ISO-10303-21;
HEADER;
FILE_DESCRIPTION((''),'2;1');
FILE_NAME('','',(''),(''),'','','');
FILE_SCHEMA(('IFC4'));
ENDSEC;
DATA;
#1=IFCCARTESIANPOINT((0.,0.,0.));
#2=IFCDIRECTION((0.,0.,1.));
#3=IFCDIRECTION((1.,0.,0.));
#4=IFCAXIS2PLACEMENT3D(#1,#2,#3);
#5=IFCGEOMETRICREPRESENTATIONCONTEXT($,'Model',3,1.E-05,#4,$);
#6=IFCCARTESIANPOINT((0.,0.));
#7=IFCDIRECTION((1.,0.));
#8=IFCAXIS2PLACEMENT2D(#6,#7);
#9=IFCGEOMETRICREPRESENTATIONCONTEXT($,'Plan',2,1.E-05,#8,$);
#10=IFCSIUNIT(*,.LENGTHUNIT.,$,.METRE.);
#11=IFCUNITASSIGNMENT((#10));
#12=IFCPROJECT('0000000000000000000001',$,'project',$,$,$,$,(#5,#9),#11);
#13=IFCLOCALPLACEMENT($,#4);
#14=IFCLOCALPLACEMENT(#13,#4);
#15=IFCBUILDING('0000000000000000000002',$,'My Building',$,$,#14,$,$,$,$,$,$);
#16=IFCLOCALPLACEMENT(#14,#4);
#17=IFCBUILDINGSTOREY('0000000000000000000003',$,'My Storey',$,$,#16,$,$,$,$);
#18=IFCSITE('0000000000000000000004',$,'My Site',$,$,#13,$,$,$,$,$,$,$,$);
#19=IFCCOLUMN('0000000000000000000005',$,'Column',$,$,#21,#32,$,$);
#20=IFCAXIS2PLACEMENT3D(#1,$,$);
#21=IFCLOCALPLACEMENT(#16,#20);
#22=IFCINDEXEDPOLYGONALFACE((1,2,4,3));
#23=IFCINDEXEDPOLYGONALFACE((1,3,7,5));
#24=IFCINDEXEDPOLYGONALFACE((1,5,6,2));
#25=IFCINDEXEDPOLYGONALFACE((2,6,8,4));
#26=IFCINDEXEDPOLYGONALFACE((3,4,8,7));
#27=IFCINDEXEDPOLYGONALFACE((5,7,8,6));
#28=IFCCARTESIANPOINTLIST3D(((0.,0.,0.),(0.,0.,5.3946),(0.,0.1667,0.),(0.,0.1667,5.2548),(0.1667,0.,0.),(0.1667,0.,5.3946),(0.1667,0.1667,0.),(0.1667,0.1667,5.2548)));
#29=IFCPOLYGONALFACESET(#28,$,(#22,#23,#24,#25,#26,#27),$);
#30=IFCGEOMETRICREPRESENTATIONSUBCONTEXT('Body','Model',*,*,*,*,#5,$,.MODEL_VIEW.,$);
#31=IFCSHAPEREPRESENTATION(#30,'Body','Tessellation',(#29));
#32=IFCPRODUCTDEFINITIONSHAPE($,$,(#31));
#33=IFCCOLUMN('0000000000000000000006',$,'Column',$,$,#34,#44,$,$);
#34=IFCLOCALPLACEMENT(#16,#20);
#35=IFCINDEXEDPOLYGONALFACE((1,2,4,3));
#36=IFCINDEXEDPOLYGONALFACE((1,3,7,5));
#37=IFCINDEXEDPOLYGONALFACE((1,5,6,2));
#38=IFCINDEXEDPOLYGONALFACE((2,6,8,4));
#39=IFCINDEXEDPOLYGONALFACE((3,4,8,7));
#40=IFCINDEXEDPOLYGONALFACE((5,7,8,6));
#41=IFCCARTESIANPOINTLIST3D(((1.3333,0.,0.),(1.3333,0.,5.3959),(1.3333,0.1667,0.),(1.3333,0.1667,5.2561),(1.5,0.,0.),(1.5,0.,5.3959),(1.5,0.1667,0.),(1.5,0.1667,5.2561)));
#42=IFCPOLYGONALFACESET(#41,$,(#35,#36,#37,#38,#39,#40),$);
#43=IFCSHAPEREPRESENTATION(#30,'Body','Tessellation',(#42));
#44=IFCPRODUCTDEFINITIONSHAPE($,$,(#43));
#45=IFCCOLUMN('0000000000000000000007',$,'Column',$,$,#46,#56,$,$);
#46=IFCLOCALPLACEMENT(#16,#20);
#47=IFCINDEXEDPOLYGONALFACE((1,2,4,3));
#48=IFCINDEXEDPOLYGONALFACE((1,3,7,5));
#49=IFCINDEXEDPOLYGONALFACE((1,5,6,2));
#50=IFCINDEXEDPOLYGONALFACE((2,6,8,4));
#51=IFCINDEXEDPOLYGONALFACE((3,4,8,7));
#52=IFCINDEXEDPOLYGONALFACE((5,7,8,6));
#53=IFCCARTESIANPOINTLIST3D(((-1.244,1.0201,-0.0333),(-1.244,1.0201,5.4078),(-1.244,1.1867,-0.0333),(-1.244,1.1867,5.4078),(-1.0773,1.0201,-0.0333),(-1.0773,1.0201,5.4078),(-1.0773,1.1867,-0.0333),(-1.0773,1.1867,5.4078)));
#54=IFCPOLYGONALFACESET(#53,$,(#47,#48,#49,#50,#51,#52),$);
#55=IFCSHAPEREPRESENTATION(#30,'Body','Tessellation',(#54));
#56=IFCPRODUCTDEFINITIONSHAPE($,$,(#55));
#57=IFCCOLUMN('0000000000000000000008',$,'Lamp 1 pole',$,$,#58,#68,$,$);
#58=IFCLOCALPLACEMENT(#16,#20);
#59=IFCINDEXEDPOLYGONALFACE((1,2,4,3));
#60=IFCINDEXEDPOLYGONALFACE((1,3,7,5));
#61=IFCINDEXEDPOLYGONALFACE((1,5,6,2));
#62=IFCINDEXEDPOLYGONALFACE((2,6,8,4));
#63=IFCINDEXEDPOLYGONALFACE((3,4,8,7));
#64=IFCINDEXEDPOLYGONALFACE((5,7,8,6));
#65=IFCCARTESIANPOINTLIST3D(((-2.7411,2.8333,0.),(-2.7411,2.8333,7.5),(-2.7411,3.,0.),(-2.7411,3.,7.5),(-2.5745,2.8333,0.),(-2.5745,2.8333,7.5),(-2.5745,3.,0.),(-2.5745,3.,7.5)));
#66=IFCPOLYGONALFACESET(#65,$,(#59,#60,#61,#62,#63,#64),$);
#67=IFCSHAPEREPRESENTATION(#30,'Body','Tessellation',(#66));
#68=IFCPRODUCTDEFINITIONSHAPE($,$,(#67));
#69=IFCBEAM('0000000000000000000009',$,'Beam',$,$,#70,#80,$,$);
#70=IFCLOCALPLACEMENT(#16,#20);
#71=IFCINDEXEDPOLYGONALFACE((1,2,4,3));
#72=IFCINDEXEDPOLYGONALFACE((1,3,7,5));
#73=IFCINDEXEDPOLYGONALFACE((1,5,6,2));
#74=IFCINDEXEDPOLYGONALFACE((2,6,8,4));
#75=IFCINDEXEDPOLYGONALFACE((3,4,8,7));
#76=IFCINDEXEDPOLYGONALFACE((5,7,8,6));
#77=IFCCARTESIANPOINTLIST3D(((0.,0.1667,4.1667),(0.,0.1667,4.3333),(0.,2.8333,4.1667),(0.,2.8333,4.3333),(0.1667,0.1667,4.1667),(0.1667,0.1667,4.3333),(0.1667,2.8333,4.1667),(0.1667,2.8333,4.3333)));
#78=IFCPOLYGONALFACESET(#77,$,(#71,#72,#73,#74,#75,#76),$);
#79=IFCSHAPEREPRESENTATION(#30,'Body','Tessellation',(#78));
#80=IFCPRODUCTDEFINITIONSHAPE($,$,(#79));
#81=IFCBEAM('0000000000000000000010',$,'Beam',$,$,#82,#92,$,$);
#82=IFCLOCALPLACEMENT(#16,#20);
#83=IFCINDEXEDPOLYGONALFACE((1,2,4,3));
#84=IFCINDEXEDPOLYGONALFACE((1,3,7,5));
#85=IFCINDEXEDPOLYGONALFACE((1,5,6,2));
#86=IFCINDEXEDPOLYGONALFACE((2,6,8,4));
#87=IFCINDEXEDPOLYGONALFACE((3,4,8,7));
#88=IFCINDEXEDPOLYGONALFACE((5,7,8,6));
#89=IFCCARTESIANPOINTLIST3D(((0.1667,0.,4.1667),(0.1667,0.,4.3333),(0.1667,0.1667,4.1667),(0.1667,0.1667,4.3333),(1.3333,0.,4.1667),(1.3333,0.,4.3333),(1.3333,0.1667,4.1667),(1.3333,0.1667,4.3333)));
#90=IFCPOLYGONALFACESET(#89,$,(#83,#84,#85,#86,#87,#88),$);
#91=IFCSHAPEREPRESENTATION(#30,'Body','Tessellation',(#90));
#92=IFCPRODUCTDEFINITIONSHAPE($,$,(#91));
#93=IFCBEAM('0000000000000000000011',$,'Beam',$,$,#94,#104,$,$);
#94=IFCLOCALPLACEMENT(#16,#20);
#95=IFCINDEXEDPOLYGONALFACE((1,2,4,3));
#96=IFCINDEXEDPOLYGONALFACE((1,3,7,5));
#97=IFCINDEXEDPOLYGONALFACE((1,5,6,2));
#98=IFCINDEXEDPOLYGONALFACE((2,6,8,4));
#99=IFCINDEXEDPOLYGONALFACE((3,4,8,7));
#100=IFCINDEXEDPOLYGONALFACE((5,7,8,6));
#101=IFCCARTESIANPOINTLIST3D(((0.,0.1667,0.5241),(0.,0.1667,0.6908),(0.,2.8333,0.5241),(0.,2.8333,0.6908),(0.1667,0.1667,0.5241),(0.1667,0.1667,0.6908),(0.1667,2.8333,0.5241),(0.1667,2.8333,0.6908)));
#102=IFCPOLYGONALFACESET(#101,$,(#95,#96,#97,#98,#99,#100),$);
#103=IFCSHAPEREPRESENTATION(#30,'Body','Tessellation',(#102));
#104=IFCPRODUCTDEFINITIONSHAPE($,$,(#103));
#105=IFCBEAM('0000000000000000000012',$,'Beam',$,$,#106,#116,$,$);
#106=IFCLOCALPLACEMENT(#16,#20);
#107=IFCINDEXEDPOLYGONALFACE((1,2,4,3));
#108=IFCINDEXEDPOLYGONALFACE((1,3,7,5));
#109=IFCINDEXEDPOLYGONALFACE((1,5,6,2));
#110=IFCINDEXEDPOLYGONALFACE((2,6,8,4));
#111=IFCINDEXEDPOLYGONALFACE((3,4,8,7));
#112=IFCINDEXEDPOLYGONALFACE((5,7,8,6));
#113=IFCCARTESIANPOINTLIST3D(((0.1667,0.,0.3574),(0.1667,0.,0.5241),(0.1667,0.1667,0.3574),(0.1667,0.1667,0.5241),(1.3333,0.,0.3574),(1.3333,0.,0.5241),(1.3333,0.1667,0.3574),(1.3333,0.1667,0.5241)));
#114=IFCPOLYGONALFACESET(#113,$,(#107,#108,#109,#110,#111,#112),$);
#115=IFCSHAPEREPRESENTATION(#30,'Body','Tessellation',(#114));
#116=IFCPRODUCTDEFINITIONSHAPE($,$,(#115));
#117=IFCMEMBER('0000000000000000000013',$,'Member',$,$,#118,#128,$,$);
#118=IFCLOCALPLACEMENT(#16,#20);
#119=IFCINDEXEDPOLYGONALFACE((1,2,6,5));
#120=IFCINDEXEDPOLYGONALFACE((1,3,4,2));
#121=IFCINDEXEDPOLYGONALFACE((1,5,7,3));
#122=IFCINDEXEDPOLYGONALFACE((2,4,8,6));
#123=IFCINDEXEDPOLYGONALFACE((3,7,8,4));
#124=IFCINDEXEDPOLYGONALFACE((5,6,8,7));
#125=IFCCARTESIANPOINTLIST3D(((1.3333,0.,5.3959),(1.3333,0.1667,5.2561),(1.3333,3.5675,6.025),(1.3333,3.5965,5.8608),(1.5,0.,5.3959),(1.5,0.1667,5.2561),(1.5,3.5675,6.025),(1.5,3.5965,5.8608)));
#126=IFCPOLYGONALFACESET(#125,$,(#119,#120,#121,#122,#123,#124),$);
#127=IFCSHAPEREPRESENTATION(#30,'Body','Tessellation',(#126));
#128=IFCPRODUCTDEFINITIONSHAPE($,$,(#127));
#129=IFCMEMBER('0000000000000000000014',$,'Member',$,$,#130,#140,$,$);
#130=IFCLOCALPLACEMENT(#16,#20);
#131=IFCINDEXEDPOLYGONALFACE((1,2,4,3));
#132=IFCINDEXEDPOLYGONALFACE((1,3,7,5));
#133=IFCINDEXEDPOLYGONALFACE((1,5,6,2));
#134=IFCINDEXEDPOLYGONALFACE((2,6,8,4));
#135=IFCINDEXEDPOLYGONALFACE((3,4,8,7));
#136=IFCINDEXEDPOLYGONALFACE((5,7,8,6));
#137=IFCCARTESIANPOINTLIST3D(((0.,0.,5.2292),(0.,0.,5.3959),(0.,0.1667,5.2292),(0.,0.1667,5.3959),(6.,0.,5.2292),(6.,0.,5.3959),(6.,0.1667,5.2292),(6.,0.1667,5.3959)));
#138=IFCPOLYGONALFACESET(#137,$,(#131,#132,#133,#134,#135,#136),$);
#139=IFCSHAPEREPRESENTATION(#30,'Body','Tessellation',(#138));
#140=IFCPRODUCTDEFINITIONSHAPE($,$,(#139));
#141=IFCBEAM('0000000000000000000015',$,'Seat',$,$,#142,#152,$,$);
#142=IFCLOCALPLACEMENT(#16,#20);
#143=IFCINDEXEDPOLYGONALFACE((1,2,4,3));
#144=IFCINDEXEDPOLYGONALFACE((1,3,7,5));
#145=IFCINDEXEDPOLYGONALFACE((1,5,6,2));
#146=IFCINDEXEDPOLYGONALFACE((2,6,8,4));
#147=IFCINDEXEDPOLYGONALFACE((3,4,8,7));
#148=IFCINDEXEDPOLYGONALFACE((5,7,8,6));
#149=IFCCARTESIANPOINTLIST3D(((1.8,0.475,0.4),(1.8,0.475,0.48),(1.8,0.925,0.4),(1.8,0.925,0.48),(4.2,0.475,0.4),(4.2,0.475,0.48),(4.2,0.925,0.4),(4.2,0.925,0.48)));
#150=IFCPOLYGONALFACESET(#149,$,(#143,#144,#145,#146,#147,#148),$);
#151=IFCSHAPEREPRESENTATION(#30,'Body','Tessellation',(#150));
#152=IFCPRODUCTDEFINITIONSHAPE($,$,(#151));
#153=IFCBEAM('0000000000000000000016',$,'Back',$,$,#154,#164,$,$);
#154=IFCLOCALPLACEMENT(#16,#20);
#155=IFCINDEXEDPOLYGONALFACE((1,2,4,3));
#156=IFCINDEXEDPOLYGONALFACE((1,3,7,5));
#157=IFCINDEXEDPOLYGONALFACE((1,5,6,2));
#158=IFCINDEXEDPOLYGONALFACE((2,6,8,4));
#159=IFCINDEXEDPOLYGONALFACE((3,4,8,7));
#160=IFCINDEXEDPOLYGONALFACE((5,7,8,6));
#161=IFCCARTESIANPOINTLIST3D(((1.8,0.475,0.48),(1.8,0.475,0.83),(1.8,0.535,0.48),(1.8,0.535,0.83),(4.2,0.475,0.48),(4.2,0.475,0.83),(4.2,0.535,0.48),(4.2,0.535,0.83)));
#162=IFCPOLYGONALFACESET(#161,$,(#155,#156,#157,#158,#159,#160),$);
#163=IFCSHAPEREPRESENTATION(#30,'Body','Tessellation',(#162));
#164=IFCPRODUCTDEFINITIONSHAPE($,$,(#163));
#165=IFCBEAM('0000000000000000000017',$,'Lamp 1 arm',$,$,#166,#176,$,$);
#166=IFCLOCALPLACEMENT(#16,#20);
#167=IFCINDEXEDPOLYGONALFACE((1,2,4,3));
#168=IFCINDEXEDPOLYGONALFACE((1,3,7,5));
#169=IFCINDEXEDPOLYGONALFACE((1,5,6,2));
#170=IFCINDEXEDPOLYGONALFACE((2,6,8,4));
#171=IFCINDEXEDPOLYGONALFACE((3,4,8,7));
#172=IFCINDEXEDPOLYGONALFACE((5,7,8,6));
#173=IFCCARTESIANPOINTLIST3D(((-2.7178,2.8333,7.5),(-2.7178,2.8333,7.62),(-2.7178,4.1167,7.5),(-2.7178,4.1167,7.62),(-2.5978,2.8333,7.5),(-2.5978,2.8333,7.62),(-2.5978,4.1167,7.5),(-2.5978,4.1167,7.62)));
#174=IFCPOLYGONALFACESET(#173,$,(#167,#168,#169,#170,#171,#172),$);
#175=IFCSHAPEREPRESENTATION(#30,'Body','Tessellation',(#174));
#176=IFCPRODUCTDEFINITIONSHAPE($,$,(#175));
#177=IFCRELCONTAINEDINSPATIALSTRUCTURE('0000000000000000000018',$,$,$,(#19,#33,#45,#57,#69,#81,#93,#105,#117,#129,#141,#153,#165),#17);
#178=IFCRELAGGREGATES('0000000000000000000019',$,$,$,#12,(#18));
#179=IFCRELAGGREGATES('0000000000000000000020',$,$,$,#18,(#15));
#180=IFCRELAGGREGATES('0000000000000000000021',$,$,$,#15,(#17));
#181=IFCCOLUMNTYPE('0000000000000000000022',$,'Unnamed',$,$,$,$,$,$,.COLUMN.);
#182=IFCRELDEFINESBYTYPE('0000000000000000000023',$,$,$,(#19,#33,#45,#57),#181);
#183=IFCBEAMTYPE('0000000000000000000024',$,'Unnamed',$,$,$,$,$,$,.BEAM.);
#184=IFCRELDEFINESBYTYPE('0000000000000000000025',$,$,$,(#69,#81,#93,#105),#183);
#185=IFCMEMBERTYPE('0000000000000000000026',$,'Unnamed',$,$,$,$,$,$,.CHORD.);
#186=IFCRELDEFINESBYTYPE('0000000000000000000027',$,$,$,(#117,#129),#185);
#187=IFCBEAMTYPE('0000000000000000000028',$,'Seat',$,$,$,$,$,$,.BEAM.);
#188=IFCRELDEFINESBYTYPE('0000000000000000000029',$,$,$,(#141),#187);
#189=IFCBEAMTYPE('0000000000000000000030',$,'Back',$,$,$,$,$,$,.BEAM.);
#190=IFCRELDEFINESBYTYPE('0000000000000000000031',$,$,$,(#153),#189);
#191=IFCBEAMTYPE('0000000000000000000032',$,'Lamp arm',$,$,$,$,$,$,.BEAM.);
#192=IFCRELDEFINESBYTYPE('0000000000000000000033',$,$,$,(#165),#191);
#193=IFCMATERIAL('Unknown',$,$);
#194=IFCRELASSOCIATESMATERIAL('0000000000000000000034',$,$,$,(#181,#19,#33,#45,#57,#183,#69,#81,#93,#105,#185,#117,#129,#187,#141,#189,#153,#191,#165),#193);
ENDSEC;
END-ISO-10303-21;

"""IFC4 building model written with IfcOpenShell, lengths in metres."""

from ifc_helpers import new_model, si_unit, frame, origin_with_axes, origin_2d_with_axis, place, context, subcontext, project, spatial, rectangle, extrude, clip, halfspace, material, material_profile, profile_set, profile_usage, type_object, element, save


model = new_model("IFC4")

# Units and contexts
model_context = context("Model", 3, precision=1e-05, world=origin_with_axes())
plan_context = context("Plan", 2, precision=1e-05, world=origin_2d_with_axis())
body_context = subcontext(model_context, "Body", "Model", "MODEL_VIEW")
ifc_project = project(units=[si_unit("LENGTHUNIT", "METRE")], contexts=[model_context, plan_context])

# Site, building, storey
site_placement = place(None, origin_with_axes())
site = spatial("IfcSite", under=ifc_project, at=site_placement, Name="My Site")
building_placement = place(site_placement, origin_with_axes())
building = spatial("IfcBuilding", under=site, at=building_placement, Name="My Building")
storey_placement = place(building_placement, origin_with_axes())
storey = spatial("IfcBuildingStorey", under=building, at=storey_placement, Name="My Storey")

# Columns
ifc_material = material(Name="Unknown")
ifc_material_profile_1 = material_profile(ifc_material, rectangle(XDim=0.1667, YDim=0.1667))
ifc_profile_set_1 = profile_set([ifc_material_profile_1])
column_type = type_object("IfcColumnType", Name="Unnamed", PredefinedType="COLUMN", material=ifc_profile_set_1)
ifc_profile_usage_1 = profile_usage(ifc_profile_set_1, cardinal=5)
column_1_placement = place(storey_placement, frame((0.0833, 0.0833, 0.0), z_axis=(0.0, 0.0, 1.0), x_axis=(1.0, 0.0, 0.0)))
element("IfcColumn", 1, at=column_1_placement, inside=storey, type_object=column_type, material=ifc_profile_usage_1, Name="Column", context=body_context, shape_type="Clipping", body=[
    clip(extrude(rectangle(XDim=0.1667, YDim=0.1667), origin_with_axes(), (0.0, 0.0, 1.0), 5.576), halfspace(frame((-0.0833, -0.0833, 5.3946), z_axis=(0.0, 0.642787, 0.766045), x_axis=(1.0, 0.0, 0.0)), False)),
])
ifc_profile_usage_2 = profile_usage(ifc_profile_set_1, cardinal=5)
column_2_placement = place(storey_placement, frame((1.4167, 0.0833, 0.0), z_axis=(0.0, 0.0, 1.0), x_axis=(1.0, 0.0, 0.0)))
element("IfcColumn", 2, at=column_2_placement, inside=storey, type_object=column_type, material=ifc_profile_usage_2, Name="Column", context=body_context, shape_type="Clipping", body=[
    clip(extrude(rectangle(XDim=0.1667, YDim=0.1667), origin_with_axes(), (0.0, 0.0, 1.0), 5.5773), halfspace(frame((-1.4167, -0.0833, 5.3959), z_axis=(0.0, 0.642787, 0.766045), x_axis=(1.0, 0.0, 0.0)), False)),
])
ifc_profile_usage_3 = profile_usage(ifc_profile_set_1, cardinal=5)
column_3_placement = place(storey_placement, frame((-1.1606, 1.1034, -0.0333), z_axis=(0.0, 0.0, 1.0), x_axis=(1.0, 0.0, 0.0)))
element("IfcColumn", 3, at=column_3_placement, inside=storey, type_object=column_type, material=ifc_profile_usage_3, Name="Column", context=body_context, shape_type="SweptSolid", body=[
    extrude(rectangle(XDim=0.1667, YDim=0.1667), origin_with_axes(), (0.0, 0.0, 1.0), 5.4411),
])
ifc_profile_usage_4 = profile_usage(ifc_profile_set_1, cardinal=5)
column_4_placement = place(storey_placement, frame((-2.6578, 2.9167, 0.0), z_axis=(0.0, 0.0, 1.0), x_axis=(1.0, 0.0, 0.0)))
element("IfcColumn", 4, at=column_4_placement, inside=storey, type_object=column_type, material=ifc_profile_usage_4, Name="Lamp 1 pole", context=body_context, shape_type="SweptSolid", body=[
    extrude(rectangle(XDim=0.1667, YDim=0.1667), origin_with_axes(), (0.0, 0.0, 1.0), 7.5),
])

# Beams
ifc_material_profile_2 = material_profile(ifc_material, rectangle(XDim=0.1667, YDim=0.1667))
ifc_profile_set_2 = profile_set([ifc_material_profile_2])
ifc_profile_usage_5 = profile_usage(ifc_profile_set_2, cardinal=5)
beam_type_1 = type_object("IfcBeamType", Name="Unnamed", PredefinedType="BEAM", material=ifc_profile_set_2)
beam_1_placement = place(storey_placement, frame((0.0833, 2.8333, 4.25), z_axis=(0.000003, -1.0, 0.0), x_axis=(1.0, 0.000003, 0.0)))
element("IfcBeam", 5, at=beam_1_placement, inside=storey, type_object=beam_type_1, material=ifc_profile_usage_5, Name="Beam", context=body_context, shape_type="SweptSolid", body=[
    extrude(rectangle(XDim=0.1667, YDim=0.1667), origin_with_axes(), (0.0, 0.0, 1.0), 2.6667),
])
ifc_profile_usage_6 = profile_usage(ifc_profile_set_2, cardinal=5)
beam_2_placement = place(storey_placement, frame((0.1667, 0.0833, 4.25), z_axis=(1.0, 0.0, 0.0), x_axis=(0.0, 1.0, 0.0)))
element("IfcBeam", 6, at=beam_2_placement, inside=storey, type_object=beam_type_1, material=ifc_profile_usage_6, Name="Beam", context=body_context, shape_type="SweptSolid", body=[
    extrude(rectangle(XDim=0.1667, YDim=0.1667), origin_with_axes(), (0.0, 0.0, 1.0), 1.1667),
])
ifc_profile_usage_7 = profile_usage(ifc_profile_set_2, cardinal=5)
beam_3_placement = place(storey_placement, frame((0.0833, 2.8333, 0.6074), z_axis=(0.000003, -1.0, 0.0), x_axis=(1.0, 0.000003, 0.0)))
element("IfcBeam", 7, at=beam_3_placement, inside=storey, type_object=beam_type_1, material=ifc_profile_usage_7, Name="Beam", context=body_context, shape_type="SweptSolid", body=[
    extrude(rectangle(XDim=0.1667, YDim=0.1667), origin_with_axes(), (0.0, 0.0, 1.0), 2.6667),
])
ifc_profile_usage_8 = profile_usage(ifc_profile_set_2, cardinal=5)
beam_4_placement = place(storey_placement, frame((0.1667, 0.0833, 0.4408), z_axis=(1.0, 0.0, 0.0), x_axis=(0.0, 1.0, 0.0)))
element("IfcBeam", 8, at=beam_4_placement, inside=storey, type_object=beam_type_1, material=ifc_profile_usage_8, Name="Beam", context=body_context, shape_type="SweptSolid", body=[
    extrude(rectangle(XDim=0.1667, YDim=0.1667), origin_with_axes(), (0.0, 0.0, 1.0), 1.1667),
])

# Members
ifc_material_profile_3 = material_profile(ifc_material, rectangle(XDim=0.1667, YDim=0.1667))
ifc_profile_set_3 = profile_set([ifc_material_profile_3])
ifc_profile_usage_9 = profile_usage(ifc_profile_set_3, cardinal=5)
member_type = type_object("IfcMemberType", Name="Unnamed", PredefinedType="CHORD", material=ifc_profile_set_3)
member_1_placement = place(storey_placement, frame((1.4167, -0.1641, 5.2823), z_axis=(0.0, 0.984808, 0.173648), x_axis=(-1.0, 0.0, 0.0)))
element("IfcMember", 9, at=member_1_placement, inside=storey, type_object=member_type, material=ifc_profile_usage_9, Name="Member", context=body_context, shape_type="Clipping", body=[
    clip(extrude(rectangle(XDim=0.1667, YDim=0.1667), origin_with_axes(), (0.0, 0.0, 1.0), 3.8039), halfspace(frame((1.4167, 0.0833, 0.1814), z_axis=(0.0, -0.642788, -0.766044), x_axis=(-1.0, 0.0, 0.0)), False)),
])
ifc_profile_usage_10 = profile_usage(ifc_profile_set_3, cardinal=5)
member_2_placement = place(storey_placement, frame((0.0, 0.0833, 5.3126), z_axis=(1.0, 0.0, 0.0), x_axis=(0.0, 1.0, 0.0)))
element("IfcMember", 10, at=member_2_placement, inside=storey, type_object=member_type, material=ifc_profile_usage_10, Name="Member", context=body_context, shape_type="SweptSolid", body=[
    extrude(rectangle(XDim=0.1667, YDim=0.1667), origin_with_axes(), (0.0, 0.0, 1.0), 6.0),
])

# Beams
ifc_material_profile_4 = material_profile(ifc_material, rectangle(XDim=0.45, YDim=0.08))
ifc_profile_set_4 = profile_set([ifc_material_profile_4])
ifc_profile_usage_11 = profile_usage(ifc_profile_set_4, cardinal=5)
beam_type_2 = type_object("IfcBeamType", Name="Seat", PredefinedType="BEAM", material=ifc_profile_set_4)
beam_5_placement = place(storey_placement, frame((1.8, 0.7, 0.44), z_axis=(1.0, 0.0, 0.0), x_axis=(0.0, 1.0, 0.0)))
element("IfcBeam", 11, at=beam_5_placement, inside=storey, type_object=beam_type_2, material=ifc_profile_usage_11, Name="Seat", context=body_context, shape_type="SweptSolid", body=[
    extrude(rectangle(XDim=0.45, YDim=0.08), origin_with_axes(), (0.0, 0.0, 1.0), 2.4),
])
ifc_material_profile_5 = material_profile(ifc_material, rectangle(XDim=0.06, YDim=0.35))
ifc_profile_set_5 = profile_set([ifc_material_profile_5])
ifc_profile_usage_12 = profile_usage(ifc_profile_set_5, cardinal=5)
beam_type_3 = type_object("IfcBeamType", Name="Back", PredefinedType="BEAM", material=ifc_profile_set_5)
beam_6_placement = place(storey_placement, frame((1.8, 0.505, 0.655), z_axis=(1.0, 0.0, 0.0), x_axis=(0.0, 1.0, 0.0)))
element("IfcBeam", 12, at=beam_6_placement, inside=storey, type_object=beam_type_3, material=ifc_profile_usage_12, Name="Back", context=body_context, shape_type="SweptSolid", body=[
    extrude(rectangle(XDim=0.06, YDim=0.35), origin_with_axes(), (0.0, 0.0, 1.0), 2.4),
])
ifc_material_profile_6 = material_profile(ifc_material, rectangle(XDim=0.12, YDim=0.12))
ifc_profile_set_6 = profile_set([ifc_material_profile_6])
ifc_profile_usage_13 = profile_usage(ifc_profile_set_6, cardinal=5)
beam_type_4 = type_object("IfcBeamType", Name="Lamp arm", PredefinedType="BEAM", material=ifc_profile_set_6)
beam_7_placement = place(storey_placement, frame((-2.6578, 2.8333, 7.56), z_axis=(0.0, 1.0, 0.0), x_axis=(1.0, 0.0, 0.0)))
element("IfcBeam", 13, at=beam_7_placement, inside=storey, type_object=beam_type_4, material=ifc_profile_usage_13, Name="Lamp 1 arm", context=body_context, shape_type="SweptSolid", body=[
    extrude(rectangle(XDim=0.12, YDim=0.12), origin_with_axes(), (0.0, 0.0, 1.0), 1.2833),
])

save(model, "model.ifc")
